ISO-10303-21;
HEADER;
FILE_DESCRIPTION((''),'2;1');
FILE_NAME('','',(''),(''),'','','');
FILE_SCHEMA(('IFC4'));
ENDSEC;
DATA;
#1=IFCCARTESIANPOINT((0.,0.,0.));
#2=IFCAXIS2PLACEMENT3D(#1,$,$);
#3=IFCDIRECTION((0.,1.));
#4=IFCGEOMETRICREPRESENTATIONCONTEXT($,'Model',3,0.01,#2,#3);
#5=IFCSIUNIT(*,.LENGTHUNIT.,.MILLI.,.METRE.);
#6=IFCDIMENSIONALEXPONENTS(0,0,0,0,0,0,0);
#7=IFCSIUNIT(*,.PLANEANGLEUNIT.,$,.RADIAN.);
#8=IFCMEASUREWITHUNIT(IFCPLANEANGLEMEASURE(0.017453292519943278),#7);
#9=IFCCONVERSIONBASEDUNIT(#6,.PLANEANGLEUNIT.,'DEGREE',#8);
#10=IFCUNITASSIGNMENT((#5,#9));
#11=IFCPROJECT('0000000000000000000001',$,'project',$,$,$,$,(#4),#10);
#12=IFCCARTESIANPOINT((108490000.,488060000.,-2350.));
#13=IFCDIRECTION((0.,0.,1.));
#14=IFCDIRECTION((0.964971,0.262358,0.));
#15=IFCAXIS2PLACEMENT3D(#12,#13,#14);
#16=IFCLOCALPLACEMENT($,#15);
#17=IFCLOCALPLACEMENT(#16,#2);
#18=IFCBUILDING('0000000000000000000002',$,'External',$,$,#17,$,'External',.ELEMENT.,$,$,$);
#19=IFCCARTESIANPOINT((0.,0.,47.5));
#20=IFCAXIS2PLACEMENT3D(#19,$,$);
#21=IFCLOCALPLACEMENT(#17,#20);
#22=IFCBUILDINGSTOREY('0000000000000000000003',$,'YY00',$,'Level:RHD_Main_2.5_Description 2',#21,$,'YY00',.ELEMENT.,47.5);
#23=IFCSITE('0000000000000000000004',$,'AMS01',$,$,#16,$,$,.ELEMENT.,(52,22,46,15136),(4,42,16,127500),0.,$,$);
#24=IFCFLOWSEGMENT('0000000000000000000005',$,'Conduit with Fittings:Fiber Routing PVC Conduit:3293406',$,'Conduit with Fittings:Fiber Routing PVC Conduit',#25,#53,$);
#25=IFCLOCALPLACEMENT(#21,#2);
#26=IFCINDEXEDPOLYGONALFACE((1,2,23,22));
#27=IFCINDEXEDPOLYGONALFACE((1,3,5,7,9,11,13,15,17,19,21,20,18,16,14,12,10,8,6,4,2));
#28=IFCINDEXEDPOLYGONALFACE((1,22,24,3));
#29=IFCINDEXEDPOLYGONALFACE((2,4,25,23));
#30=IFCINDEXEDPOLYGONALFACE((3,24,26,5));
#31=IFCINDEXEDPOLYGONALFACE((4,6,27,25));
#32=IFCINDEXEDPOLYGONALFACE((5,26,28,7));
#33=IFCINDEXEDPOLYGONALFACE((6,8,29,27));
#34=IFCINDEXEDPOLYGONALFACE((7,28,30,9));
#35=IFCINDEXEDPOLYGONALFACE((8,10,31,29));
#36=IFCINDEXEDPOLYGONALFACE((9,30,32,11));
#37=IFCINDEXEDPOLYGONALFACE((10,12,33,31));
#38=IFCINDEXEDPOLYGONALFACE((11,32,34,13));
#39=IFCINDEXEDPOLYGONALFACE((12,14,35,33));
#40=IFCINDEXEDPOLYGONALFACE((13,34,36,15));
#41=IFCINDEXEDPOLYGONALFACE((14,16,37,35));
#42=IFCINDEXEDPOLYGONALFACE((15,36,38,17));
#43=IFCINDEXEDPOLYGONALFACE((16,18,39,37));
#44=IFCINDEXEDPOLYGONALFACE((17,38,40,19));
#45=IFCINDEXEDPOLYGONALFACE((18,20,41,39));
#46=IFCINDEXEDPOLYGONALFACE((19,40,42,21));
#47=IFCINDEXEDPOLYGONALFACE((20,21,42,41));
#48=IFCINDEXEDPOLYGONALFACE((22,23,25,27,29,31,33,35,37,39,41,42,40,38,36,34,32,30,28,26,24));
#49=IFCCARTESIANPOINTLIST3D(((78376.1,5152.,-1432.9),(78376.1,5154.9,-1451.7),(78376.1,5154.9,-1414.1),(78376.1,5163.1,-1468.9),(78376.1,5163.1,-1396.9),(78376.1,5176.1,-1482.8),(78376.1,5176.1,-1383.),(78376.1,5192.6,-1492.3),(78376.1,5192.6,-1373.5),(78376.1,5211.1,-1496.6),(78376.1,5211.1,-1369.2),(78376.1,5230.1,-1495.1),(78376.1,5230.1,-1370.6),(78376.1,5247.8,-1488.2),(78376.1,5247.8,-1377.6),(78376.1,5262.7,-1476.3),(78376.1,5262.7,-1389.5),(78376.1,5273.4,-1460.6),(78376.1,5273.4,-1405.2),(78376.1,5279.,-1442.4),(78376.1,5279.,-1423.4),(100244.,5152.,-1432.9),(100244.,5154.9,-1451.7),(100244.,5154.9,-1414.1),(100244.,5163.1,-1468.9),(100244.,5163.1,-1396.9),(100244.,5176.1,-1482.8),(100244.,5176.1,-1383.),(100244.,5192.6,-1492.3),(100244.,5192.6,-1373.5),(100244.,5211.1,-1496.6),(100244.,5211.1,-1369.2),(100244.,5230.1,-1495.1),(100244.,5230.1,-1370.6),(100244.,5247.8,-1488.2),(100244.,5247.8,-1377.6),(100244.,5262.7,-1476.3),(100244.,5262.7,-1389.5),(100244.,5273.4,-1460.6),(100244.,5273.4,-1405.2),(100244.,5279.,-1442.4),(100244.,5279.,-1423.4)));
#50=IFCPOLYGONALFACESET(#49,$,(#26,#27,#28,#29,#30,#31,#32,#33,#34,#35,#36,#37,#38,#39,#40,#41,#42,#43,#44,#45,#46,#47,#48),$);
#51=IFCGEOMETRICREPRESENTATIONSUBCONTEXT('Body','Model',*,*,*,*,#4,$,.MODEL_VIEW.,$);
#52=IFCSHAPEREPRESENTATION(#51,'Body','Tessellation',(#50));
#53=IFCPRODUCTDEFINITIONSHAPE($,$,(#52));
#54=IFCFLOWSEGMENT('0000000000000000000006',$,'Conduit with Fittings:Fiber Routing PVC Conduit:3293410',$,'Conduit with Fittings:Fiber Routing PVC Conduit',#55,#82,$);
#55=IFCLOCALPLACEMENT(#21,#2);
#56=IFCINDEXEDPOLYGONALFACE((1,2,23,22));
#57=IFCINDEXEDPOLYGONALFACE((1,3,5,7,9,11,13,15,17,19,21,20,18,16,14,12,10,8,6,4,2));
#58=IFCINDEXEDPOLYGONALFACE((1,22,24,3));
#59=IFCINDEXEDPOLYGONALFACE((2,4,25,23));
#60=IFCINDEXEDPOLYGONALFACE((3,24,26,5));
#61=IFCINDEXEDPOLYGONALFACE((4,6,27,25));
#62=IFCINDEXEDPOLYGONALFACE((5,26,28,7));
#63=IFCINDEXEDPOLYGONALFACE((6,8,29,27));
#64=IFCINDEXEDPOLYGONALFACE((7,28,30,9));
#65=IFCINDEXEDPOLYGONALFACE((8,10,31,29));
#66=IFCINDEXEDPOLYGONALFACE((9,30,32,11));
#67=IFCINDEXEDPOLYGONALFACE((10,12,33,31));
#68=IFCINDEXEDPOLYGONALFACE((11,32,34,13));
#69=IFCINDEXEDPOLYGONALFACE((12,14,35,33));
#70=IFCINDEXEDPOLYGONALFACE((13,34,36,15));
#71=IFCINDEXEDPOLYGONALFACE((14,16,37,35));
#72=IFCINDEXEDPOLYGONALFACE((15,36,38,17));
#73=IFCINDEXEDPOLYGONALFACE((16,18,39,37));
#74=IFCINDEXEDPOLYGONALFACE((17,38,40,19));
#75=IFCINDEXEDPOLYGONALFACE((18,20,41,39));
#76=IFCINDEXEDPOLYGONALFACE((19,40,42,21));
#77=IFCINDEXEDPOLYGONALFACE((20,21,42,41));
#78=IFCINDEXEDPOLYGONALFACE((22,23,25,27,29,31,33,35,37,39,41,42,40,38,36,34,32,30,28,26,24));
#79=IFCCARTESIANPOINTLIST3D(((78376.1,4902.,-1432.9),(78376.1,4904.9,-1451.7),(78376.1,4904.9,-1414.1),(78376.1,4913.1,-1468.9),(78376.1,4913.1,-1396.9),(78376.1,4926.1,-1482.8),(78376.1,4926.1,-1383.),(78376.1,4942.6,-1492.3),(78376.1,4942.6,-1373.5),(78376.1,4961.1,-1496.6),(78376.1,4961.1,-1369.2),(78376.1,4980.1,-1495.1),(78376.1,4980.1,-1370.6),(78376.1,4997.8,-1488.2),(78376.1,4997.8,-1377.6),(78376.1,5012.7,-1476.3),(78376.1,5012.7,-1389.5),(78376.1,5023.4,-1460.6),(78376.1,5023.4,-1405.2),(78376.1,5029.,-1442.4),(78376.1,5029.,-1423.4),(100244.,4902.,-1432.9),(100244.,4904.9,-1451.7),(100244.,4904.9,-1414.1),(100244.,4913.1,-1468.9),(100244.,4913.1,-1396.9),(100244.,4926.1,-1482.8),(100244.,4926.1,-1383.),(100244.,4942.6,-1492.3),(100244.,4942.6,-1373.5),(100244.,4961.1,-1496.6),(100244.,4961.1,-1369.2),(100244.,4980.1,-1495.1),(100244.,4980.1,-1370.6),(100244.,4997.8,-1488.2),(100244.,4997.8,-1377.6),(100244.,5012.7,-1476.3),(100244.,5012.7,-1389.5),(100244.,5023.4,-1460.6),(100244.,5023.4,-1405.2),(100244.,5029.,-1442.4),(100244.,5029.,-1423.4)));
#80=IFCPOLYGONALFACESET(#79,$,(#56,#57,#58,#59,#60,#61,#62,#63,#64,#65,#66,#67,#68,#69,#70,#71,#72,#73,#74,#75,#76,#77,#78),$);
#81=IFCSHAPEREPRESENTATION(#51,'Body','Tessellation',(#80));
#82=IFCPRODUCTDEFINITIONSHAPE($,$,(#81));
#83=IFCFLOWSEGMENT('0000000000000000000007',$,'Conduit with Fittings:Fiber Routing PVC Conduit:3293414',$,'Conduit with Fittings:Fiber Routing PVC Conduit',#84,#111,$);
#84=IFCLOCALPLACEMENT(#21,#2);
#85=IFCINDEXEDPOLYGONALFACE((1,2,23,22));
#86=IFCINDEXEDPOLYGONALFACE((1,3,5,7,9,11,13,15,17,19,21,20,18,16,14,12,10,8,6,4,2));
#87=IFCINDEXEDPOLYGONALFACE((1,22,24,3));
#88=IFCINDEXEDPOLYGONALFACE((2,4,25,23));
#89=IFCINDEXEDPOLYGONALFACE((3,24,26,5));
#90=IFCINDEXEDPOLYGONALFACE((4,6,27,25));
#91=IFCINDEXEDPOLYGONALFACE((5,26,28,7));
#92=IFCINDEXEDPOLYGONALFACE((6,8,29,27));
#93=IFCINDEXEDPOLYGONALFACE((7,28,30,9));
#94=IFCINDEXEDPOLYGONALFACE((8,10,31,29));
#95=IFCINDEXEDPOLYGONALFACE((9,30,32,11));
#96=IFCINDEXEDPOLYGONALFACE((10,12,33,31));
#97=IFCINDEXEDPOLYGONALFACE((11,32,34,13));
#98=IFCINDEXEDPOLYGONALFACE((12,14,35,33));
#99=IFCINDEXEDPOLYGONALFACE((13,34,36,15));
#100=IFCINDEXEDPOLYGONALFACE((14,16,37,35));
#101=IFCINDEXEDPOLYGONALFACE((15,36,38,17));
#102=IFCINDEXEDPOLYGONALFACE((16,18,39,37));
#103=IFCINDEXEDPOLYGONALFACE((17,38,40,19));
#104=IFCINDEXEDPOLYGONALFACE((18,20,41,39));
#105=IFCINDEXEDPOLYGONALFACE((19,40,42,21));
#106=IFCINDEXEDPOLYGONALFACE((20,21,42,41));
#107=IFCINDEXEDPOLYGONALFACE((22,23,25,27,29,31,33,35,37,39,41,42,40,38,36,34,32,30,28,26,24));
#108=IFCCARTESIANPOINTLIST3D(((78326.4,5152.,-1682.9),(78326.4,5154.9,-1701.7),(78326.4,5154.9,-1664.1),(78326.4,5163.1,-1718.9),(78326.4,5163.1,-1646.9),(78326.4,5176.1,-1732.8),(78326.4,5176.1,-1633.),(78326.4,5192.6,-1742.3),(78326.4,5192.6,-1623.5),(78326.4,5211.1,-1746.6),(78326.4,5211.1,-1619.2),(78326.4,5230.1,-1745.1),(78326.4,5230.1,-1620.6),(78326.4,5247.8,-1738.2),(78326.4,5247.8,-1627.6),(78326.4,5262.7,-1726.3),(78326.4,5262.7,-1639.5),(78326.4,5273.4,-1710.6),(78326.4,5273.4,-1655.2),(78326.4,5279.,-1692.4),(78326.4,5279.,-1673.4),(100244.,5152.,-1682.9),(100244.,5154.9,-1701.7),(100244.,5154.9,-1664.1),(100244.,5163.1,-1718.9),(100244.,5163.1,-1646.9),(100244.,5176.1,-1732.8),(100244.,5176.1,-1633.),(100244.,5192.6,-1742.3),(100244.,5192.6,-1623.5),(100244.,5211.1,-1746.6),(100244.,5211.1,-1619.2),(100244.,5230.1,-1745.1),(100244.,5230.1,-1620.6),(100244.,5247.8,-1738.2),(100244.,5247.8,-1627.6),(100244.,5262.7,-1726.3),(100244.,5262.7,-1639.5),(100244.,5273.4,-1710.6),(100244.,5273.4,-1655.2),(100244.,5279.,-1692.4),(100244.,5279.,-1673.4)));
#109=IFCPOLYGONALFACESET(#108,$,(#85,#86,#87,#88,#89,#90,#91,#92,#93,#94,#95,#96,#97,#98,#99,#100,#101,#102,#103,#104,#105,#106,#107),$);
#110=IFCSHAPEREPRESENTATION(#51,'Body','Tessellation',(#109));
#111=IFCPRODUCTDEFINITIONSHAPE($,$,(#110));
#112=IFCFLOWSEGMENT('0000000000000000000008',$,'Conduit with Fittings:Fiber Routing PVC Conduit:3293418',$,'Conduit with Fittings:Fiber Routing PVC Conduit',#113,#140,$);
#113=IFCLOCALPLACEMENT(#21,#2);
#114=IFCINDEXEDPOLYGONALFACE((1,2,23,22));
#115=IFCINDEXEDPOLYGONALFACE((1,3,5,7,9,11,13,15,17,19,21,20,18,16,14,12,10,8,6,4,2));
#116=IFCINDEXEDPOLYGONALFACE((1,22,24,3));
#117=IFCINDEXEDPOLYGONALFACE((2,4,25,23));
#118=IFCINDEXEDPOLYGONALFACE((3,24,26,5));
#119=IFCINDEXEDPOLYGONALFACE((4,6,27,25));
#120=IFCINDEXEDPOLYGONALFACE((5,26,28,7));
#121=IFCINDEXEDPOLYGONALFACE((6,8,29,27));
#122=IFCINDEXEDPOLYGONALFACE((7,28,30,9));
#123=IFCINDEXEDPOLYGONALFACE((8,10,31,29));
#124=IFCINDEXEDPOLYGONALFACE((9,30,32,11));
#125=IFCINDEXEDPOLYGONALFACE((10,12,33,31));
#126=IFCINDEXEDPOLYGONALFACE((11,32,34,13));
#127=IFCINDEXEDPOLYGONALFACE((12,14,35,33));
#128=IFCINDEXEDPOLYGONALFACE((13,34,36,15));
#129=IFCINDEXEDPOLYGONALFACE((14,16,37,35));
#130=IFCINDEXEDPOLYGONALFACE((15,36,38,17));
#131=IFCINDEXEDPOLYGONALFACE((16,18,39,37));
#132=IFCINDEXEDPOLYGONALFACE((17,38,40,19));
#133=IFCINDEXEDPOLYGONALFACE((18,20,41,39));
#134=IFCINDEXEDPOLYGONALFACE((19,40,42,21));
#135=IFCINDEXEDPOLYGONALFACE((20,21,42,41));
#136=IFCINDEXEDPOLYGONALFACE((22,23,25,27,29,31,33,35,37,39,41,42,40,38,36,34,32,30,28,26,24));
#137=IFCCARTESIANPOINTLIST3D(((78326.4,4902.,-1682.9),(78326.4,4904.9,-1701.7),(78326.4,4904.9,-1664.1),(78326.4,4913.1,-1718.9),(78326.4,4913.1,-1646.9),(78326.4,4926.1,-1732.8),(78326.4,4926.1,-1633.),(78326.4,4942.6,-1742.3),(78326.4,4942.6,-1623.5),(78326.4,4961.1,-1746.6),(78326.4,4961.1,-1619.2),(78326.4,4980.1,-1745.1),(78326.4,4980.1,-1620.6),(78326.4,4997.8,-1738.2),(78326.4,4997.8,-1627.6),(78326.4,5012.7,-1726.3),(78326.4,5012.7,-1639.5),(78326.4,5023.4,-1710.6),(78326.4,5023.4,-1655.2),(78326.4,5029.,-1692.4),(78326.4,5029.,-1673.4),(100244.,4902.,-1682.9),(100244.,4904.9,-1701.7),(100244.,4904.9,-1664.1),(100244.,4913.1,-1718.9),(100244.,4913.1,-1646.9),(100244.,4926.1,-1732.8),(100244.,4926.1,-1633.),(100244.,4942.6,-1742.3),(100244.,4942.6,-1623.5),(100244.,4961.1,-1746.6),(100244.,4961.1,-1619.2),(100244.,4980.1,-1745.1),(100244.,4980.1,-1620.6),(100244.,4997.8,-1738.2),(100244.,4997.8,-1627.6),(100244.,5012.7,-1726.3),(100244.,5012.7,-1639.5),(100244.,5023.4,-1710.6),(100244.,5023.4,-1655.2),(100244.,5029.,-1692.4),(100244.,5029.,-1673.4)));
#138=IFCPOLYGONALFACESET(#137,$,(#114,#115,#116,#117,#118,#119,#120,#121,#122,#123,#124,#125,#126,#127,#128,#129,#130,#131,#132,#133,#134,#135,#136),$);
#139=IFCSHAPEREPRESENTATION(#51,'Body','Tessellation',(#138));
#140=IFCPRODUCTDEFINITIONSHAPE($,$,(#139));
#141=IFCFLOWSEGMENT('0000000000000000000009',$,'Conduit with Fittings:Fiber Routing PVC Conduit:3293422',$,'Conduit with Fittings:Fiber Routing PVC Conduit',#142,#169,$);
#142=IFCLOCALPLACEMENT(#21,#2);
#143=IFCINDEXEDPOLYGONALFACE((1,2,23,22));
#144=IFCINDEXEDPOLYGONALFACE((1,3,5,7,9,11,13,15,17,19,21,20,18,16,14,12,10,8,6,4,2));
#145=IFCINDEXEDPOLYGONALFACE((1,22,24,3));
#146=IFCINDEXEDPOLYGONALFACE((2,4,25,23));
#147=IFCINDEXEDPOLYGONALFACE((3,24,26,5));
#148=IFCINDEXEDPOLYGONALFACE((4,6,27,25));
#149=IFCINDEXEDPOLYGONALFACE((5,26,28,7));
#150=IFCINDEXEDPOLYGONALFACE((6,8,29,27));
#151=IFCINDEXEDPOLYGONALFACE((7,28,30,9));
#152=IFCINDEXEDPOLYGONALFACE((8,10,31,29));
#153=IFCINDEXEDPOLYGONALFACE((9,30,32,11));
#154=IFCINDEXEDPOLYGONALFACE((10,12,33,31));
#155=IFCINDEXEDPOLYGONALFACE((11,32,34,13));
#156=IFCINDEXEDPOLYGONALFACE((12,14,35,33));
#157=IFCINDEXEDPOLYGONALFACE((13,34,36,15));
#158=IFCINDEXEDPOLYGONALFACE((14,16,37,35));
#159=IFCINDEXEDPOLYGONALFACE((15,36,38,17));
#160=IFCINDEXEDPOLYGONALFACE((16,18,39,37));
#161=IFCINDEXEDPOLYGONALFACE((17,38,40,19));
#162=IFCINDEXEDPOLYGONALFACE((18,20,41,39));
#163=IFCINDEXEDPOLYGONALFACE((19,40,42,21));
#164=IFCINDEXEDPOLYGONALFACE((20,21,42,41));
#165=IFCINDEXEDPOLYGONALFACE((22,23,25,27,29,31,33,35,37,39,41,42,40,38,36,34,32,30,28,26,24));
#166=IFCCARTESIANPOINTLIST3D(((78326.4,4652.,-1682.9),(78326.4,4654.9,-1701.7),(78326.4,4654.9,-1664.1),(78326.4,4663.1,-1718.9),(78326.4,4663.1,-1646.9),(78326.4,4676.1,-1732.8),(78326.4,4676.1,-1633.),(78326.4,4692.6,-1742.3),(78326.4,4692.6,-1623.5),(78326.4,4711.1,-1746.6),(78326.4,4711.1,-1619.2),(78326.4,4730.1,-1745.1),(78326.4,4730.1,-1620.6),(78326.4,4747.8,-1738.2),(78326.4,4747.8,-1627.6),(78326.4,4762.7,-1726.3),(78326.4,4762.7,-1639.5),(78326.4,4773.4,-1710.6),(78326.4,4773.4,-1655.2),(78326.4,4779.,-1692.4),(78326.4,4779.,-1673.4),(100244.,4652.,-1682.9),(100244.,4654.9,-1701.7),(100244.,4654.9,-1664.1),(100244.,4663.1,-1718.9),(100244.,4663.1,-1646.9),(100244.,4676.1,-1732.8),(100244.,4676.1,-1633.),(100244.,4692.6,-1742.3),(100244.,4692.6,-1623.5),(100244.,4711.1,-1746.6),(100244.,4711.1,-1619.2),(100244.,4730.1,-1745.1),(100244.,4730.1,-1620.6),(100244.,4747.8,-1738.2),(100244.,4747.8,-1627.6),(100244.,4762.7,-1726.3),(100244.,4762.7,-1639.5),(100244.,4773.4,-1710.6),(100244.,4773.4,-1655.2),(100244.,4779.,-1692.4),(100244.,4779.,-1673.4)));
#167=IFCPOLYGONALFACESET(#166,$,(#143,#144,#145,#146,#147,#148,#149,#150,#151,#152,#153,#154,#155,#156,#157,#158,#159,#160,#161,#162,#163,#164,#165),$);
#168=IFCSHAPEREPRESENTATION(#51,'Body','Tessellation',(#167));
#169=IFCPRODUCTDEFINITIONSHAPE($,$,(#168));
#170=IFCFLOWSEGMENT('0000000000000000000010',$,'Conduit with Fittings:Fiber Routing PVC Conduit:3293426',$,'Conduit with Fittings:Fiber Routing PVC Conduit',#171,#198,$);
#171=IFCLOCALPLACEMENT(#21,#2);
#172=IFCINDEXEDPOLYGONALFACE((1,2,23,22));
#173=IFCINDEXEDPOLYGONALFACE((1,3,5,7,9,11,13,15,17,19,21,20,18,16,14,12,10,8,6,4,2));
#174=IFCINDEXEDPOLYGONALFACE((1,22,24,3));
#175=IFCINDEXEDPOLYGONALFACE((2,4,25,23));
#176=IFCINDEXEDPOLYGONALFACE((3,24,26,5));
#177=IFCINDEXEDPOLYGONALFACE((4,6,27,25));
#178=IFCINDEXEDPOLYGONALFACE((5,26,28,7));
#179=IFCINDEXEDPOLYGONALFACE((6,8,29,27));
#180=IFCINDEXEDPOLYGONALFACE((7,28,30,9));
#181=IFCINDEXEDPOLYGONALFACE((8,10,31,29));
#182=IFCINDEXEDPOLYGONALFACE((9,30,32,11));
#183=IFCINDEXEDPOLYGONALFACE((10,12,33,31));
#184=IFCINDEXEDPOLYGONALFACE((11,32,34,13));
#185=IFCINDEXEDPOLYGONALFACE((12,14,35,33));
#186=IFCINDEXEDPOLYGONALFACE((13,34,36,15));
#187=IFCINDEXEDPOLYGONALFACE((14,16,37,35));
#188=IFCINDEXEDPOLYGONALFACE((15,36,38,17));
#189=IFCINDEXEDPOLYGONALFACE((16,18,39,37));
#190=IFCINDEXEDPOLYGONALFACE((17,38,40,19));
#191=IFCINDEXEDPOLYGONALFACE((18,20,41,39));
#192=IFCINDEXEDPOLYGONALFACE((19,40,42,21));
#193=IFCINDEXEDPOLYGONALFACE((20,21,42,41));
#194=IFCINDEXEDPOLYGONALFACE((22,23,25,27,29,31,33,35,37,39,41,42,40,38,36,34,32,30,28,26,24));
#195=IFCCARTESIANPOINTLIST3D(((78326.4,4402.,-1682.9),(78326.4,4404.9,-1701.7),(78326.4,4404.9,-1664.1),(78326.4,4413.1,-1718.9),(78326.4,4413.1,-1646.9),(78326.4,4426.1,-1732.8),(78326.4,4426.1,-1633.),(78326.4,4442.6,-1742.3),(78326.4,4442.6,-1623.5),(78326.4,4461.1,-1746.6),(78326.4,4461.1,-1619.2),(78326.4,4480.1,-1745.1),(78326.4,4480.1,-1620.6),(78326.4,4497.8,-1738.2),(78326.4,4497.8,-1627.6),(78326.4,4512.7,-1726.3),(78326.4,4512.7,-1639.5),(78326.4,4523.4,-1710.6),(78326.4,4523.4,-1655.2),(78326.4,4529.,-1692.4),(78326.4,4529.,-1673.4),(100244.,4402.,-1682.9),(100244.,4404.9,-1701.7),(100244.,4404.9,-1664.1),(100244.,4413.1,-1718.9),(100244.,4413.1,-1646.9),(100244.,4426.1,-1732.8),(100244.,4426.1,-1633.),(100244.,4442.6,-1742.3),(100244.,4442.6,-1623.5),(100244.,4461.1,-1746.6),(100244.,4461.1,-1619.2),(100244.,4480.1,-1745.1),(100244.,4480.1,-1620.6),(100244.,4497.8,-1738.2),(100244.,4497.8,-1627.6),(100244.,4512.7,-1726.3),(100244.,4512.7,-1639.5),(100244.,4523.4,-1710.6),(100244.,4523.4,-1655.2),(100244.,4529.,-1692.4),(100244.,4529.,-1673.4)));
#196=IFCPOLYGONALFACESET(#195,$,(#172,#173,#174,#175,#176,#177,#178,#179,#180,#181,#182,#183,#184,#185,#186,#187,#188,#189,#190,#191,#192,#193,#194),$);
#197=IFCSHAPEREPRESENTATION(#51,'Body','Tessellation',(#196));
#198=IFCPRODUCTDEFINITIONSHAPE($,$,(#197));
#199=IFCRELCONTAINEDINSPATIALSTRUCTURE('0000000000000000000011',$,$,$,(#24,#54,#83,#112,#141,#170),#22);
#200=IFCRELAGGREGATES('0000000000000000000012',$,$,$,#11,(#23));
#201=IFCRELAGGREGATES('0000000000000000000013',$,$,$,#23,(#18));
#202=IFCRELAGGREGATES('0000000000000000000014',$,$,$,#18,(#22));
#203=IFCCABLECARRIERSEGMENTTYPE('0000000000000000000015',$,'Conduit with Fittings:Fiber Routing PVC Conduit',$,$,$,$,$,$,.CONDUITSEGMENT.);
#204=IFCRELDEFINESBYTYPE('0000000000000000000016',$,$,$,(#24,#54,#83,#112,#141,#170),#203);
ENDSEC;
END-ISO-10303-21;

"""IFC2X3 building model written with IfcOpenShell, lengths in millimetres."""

from ifc_helpers import new_model, entity, si_unit, converted_unit, direction, frame, frame_2d, origin, origin_2d_with_axis, place, context, subcontext, project, spatial, circle, extrude, type_object, element, save


model = new_model("IFC2X3")

# Units and contexts
model_context = context("Model", 3, precision=0.01, world=origin(), true_north=direction((0.0, 1.0)))
body_context = subcontext(model_context, "Body", "Model", "MODEL_VIEW")
ifc_project = project(units=[si_unit("LENGTHUNIT", "METRE", prefix="MILLI"), converted_unit("PLANEANGLEUNIT", "DEGREE", entity("IfcPlaneAngleMeasure", 0.017453292519943278), si_unit("PLANEANGLEUNIT", "RADIAN"), dimensions=[0, 0, 0, 0, 0, 0, 0])], contexts=[model_context])

# Site, building, storey
site_placement = place(None, frame((108490000.0, 488060000.0, -2350.0), z_axis=(0.0, 0.0, 1.0), x_axis=(0.964971, 0.262358, 0.0)))
site = spatial("IfcSite", under=ifc_project, at=site_placement, Name="AMS01", CompositionType="ELEMENT", RefLatitude=(52, 22, 46, 15136), RefLongitude=(4, 42, 16, 127500), RefElevation=0.0)
building_placement = place(site_placement, origin())
building = spatial("IfcBuilding", under=site, at=building_placement, Name="External", LongName="External", CompositionType="ELEMENT")
storey_placement = place(building_placement, frame((0.0, 0.0, 47.5)))
storey = spatial("IfcBuildingStorey", under=building, at=storey_placement, Name="YY00", ObjectType="Level:RHD_Main_2.5_Description 2", LongName="YY00", CompositionType="ELEMENT", Elevation=47.5)

# Flow segments
cable_carrier_segment_type = type_object("IfcCableCarrierSegmentType", Name="Conduit with Fittings:Fiber Routing PVC Conduit", PredefinedType="CONDUITSEGMENT")
flow_segment_1_placement = place(storey_placement, origin())
element("IfcFlowSegment", 1, at=flow_segment_1_placement, inside=storey, type_object=cable_carrier_segment_type, Name="Conduit with Fittings:Fiber Routing PVC Conduit:3293406", ObjectType="Conduit with Fittings:Fiber Routing PVC Conduit", context=body_context, shape_type="SweptSolid", body=[
    extrude(circle(Radius=63.9, at=origin_2d_with_axis()), frame((78376.1, 5215.9, -1432.9), z_axis=(1.0, 0.0, 0.0), x_axis=(0.0, -1.0, 0.0)), (0.0, 0.0, 1.0), 21867.9),
])
flow_segment_2_placement = place(storey_placement, origin())
element("IfcFlowSegment", 2, at=flow_segment_2_placement, inside=storey, type_object=cable_carrier_segment_type, Name="Conduit with Fittings:Fiber Routing PVC Conduit:3293410", ObjectType="Conduit with Fittings:Fiber Routing PVC Conduit", context=body_context, shape_type="SweptSolid", body=[
    extrude(circle(Radius=63.9, at=origin_2d_with_axis()), frame((78376.1, 4965.9, -1432.9), z_axis=(1.0, 0.0, 0.0), x_axis=(0.0, -1.0, 0.0)), (0.0, 0.0, 1.0), 21867.9),
])
flow_segment_3_placement = place(storey_placement, origin())
element("IfcFlowSegment", 3, at=flow_segment_3_placement, inside=storey, type_object=cable_carrier_segment_type, Name="Conduit with Fittings:Fiber Routing PVC Conduit:3293414", ObjectType="Conduit with Fittings:Fiber Routing PVC Conduit", context=body_context, shape_type="SweptSolid", body=[
    extrude(circle(Radius=63.9, at=origin_2d_with_axis()), frame((78326.4, 5215.9, -1682.9), z_axis=(1.0, 0.0, 0.0), x_axis=(0.0, -1.0, 0.0)), (0.0, 0.0, 1.0), 21917.6),
])
flow_segment_4_placement = place(storey_placement, origin())
element("IfcFlowSegment", 4, at=flow_segment_4_placement, inside=storey, type_object=cable_carrier_segment_type, Name="Conduit with Fittings:Fiber Routing PVC Conduit:3293418", ObjectType="Conduit with Fittings:Fiber Routing PVC Conduit", context=body_context, shape_type="SweptSolid", body=[
    extrude(circle(Radius=63.9, at=origin_2d_with_axis()), frame((78326.4, 4965.9, -1682.9), z_axis=(1.0, 0.0, 0.0), x_axis=(0.0, -1.0, 0.0)), (0.0, 0.0, 1.0), 21917.6),
])
flow_segment_5_placement = place(storey_placement, origin())
element("IfcFlowSegment", 5, at=flow_segment_5_placement, inside=storey, type_object=cable_carrier_segment_type, Name="Conduit with Fittings:Fiber Routing PVC Conduit:3293422", ObjectType="Conduit with Fittings:Fiber Routing PVC Conduit", context=body_context, shape_type="SweptSolid", body=[
    extrude(circle(Radius=63.9, at=frame_2d((0.0, 0.0), x_axis=(1.0, 0.0))), frame((78326.4, 4715.9, -1682.9), z_axis=(1.0, 0.0, 0.0), x_axis=(0.0, -1.0, 0.0)), (0.0, 0.0, 1.0), 21917.6),
])
flow_segment_6_placement = place(storey_placement, origin())
element("IfcFlowSegment", 6, at=flow_segment_6_placement, inside=storey, type_object=cable_carrier_segment_type, Name="Conduit with Fittings:Fiber Routing PVC Conduit:3293426", ObjectType="Conduit with Fittings:Fiber Routing PVC Conduit", context=body_context, shape_type="SweptSolid", body=[
    extrude(circle(Radius=63.9, at=frame_2d((0.0, 0.0), x_axis=(1.0, 0.0))), frame((78326.4, 4465.9, -1682.9), z_axis=(1.0, 0.0, 0.0), x_axis=(0.0, -1.0, 0.0)), (0.0, 0.0, 1.0), 21917.6),
])

save(model, "model.ifc")
